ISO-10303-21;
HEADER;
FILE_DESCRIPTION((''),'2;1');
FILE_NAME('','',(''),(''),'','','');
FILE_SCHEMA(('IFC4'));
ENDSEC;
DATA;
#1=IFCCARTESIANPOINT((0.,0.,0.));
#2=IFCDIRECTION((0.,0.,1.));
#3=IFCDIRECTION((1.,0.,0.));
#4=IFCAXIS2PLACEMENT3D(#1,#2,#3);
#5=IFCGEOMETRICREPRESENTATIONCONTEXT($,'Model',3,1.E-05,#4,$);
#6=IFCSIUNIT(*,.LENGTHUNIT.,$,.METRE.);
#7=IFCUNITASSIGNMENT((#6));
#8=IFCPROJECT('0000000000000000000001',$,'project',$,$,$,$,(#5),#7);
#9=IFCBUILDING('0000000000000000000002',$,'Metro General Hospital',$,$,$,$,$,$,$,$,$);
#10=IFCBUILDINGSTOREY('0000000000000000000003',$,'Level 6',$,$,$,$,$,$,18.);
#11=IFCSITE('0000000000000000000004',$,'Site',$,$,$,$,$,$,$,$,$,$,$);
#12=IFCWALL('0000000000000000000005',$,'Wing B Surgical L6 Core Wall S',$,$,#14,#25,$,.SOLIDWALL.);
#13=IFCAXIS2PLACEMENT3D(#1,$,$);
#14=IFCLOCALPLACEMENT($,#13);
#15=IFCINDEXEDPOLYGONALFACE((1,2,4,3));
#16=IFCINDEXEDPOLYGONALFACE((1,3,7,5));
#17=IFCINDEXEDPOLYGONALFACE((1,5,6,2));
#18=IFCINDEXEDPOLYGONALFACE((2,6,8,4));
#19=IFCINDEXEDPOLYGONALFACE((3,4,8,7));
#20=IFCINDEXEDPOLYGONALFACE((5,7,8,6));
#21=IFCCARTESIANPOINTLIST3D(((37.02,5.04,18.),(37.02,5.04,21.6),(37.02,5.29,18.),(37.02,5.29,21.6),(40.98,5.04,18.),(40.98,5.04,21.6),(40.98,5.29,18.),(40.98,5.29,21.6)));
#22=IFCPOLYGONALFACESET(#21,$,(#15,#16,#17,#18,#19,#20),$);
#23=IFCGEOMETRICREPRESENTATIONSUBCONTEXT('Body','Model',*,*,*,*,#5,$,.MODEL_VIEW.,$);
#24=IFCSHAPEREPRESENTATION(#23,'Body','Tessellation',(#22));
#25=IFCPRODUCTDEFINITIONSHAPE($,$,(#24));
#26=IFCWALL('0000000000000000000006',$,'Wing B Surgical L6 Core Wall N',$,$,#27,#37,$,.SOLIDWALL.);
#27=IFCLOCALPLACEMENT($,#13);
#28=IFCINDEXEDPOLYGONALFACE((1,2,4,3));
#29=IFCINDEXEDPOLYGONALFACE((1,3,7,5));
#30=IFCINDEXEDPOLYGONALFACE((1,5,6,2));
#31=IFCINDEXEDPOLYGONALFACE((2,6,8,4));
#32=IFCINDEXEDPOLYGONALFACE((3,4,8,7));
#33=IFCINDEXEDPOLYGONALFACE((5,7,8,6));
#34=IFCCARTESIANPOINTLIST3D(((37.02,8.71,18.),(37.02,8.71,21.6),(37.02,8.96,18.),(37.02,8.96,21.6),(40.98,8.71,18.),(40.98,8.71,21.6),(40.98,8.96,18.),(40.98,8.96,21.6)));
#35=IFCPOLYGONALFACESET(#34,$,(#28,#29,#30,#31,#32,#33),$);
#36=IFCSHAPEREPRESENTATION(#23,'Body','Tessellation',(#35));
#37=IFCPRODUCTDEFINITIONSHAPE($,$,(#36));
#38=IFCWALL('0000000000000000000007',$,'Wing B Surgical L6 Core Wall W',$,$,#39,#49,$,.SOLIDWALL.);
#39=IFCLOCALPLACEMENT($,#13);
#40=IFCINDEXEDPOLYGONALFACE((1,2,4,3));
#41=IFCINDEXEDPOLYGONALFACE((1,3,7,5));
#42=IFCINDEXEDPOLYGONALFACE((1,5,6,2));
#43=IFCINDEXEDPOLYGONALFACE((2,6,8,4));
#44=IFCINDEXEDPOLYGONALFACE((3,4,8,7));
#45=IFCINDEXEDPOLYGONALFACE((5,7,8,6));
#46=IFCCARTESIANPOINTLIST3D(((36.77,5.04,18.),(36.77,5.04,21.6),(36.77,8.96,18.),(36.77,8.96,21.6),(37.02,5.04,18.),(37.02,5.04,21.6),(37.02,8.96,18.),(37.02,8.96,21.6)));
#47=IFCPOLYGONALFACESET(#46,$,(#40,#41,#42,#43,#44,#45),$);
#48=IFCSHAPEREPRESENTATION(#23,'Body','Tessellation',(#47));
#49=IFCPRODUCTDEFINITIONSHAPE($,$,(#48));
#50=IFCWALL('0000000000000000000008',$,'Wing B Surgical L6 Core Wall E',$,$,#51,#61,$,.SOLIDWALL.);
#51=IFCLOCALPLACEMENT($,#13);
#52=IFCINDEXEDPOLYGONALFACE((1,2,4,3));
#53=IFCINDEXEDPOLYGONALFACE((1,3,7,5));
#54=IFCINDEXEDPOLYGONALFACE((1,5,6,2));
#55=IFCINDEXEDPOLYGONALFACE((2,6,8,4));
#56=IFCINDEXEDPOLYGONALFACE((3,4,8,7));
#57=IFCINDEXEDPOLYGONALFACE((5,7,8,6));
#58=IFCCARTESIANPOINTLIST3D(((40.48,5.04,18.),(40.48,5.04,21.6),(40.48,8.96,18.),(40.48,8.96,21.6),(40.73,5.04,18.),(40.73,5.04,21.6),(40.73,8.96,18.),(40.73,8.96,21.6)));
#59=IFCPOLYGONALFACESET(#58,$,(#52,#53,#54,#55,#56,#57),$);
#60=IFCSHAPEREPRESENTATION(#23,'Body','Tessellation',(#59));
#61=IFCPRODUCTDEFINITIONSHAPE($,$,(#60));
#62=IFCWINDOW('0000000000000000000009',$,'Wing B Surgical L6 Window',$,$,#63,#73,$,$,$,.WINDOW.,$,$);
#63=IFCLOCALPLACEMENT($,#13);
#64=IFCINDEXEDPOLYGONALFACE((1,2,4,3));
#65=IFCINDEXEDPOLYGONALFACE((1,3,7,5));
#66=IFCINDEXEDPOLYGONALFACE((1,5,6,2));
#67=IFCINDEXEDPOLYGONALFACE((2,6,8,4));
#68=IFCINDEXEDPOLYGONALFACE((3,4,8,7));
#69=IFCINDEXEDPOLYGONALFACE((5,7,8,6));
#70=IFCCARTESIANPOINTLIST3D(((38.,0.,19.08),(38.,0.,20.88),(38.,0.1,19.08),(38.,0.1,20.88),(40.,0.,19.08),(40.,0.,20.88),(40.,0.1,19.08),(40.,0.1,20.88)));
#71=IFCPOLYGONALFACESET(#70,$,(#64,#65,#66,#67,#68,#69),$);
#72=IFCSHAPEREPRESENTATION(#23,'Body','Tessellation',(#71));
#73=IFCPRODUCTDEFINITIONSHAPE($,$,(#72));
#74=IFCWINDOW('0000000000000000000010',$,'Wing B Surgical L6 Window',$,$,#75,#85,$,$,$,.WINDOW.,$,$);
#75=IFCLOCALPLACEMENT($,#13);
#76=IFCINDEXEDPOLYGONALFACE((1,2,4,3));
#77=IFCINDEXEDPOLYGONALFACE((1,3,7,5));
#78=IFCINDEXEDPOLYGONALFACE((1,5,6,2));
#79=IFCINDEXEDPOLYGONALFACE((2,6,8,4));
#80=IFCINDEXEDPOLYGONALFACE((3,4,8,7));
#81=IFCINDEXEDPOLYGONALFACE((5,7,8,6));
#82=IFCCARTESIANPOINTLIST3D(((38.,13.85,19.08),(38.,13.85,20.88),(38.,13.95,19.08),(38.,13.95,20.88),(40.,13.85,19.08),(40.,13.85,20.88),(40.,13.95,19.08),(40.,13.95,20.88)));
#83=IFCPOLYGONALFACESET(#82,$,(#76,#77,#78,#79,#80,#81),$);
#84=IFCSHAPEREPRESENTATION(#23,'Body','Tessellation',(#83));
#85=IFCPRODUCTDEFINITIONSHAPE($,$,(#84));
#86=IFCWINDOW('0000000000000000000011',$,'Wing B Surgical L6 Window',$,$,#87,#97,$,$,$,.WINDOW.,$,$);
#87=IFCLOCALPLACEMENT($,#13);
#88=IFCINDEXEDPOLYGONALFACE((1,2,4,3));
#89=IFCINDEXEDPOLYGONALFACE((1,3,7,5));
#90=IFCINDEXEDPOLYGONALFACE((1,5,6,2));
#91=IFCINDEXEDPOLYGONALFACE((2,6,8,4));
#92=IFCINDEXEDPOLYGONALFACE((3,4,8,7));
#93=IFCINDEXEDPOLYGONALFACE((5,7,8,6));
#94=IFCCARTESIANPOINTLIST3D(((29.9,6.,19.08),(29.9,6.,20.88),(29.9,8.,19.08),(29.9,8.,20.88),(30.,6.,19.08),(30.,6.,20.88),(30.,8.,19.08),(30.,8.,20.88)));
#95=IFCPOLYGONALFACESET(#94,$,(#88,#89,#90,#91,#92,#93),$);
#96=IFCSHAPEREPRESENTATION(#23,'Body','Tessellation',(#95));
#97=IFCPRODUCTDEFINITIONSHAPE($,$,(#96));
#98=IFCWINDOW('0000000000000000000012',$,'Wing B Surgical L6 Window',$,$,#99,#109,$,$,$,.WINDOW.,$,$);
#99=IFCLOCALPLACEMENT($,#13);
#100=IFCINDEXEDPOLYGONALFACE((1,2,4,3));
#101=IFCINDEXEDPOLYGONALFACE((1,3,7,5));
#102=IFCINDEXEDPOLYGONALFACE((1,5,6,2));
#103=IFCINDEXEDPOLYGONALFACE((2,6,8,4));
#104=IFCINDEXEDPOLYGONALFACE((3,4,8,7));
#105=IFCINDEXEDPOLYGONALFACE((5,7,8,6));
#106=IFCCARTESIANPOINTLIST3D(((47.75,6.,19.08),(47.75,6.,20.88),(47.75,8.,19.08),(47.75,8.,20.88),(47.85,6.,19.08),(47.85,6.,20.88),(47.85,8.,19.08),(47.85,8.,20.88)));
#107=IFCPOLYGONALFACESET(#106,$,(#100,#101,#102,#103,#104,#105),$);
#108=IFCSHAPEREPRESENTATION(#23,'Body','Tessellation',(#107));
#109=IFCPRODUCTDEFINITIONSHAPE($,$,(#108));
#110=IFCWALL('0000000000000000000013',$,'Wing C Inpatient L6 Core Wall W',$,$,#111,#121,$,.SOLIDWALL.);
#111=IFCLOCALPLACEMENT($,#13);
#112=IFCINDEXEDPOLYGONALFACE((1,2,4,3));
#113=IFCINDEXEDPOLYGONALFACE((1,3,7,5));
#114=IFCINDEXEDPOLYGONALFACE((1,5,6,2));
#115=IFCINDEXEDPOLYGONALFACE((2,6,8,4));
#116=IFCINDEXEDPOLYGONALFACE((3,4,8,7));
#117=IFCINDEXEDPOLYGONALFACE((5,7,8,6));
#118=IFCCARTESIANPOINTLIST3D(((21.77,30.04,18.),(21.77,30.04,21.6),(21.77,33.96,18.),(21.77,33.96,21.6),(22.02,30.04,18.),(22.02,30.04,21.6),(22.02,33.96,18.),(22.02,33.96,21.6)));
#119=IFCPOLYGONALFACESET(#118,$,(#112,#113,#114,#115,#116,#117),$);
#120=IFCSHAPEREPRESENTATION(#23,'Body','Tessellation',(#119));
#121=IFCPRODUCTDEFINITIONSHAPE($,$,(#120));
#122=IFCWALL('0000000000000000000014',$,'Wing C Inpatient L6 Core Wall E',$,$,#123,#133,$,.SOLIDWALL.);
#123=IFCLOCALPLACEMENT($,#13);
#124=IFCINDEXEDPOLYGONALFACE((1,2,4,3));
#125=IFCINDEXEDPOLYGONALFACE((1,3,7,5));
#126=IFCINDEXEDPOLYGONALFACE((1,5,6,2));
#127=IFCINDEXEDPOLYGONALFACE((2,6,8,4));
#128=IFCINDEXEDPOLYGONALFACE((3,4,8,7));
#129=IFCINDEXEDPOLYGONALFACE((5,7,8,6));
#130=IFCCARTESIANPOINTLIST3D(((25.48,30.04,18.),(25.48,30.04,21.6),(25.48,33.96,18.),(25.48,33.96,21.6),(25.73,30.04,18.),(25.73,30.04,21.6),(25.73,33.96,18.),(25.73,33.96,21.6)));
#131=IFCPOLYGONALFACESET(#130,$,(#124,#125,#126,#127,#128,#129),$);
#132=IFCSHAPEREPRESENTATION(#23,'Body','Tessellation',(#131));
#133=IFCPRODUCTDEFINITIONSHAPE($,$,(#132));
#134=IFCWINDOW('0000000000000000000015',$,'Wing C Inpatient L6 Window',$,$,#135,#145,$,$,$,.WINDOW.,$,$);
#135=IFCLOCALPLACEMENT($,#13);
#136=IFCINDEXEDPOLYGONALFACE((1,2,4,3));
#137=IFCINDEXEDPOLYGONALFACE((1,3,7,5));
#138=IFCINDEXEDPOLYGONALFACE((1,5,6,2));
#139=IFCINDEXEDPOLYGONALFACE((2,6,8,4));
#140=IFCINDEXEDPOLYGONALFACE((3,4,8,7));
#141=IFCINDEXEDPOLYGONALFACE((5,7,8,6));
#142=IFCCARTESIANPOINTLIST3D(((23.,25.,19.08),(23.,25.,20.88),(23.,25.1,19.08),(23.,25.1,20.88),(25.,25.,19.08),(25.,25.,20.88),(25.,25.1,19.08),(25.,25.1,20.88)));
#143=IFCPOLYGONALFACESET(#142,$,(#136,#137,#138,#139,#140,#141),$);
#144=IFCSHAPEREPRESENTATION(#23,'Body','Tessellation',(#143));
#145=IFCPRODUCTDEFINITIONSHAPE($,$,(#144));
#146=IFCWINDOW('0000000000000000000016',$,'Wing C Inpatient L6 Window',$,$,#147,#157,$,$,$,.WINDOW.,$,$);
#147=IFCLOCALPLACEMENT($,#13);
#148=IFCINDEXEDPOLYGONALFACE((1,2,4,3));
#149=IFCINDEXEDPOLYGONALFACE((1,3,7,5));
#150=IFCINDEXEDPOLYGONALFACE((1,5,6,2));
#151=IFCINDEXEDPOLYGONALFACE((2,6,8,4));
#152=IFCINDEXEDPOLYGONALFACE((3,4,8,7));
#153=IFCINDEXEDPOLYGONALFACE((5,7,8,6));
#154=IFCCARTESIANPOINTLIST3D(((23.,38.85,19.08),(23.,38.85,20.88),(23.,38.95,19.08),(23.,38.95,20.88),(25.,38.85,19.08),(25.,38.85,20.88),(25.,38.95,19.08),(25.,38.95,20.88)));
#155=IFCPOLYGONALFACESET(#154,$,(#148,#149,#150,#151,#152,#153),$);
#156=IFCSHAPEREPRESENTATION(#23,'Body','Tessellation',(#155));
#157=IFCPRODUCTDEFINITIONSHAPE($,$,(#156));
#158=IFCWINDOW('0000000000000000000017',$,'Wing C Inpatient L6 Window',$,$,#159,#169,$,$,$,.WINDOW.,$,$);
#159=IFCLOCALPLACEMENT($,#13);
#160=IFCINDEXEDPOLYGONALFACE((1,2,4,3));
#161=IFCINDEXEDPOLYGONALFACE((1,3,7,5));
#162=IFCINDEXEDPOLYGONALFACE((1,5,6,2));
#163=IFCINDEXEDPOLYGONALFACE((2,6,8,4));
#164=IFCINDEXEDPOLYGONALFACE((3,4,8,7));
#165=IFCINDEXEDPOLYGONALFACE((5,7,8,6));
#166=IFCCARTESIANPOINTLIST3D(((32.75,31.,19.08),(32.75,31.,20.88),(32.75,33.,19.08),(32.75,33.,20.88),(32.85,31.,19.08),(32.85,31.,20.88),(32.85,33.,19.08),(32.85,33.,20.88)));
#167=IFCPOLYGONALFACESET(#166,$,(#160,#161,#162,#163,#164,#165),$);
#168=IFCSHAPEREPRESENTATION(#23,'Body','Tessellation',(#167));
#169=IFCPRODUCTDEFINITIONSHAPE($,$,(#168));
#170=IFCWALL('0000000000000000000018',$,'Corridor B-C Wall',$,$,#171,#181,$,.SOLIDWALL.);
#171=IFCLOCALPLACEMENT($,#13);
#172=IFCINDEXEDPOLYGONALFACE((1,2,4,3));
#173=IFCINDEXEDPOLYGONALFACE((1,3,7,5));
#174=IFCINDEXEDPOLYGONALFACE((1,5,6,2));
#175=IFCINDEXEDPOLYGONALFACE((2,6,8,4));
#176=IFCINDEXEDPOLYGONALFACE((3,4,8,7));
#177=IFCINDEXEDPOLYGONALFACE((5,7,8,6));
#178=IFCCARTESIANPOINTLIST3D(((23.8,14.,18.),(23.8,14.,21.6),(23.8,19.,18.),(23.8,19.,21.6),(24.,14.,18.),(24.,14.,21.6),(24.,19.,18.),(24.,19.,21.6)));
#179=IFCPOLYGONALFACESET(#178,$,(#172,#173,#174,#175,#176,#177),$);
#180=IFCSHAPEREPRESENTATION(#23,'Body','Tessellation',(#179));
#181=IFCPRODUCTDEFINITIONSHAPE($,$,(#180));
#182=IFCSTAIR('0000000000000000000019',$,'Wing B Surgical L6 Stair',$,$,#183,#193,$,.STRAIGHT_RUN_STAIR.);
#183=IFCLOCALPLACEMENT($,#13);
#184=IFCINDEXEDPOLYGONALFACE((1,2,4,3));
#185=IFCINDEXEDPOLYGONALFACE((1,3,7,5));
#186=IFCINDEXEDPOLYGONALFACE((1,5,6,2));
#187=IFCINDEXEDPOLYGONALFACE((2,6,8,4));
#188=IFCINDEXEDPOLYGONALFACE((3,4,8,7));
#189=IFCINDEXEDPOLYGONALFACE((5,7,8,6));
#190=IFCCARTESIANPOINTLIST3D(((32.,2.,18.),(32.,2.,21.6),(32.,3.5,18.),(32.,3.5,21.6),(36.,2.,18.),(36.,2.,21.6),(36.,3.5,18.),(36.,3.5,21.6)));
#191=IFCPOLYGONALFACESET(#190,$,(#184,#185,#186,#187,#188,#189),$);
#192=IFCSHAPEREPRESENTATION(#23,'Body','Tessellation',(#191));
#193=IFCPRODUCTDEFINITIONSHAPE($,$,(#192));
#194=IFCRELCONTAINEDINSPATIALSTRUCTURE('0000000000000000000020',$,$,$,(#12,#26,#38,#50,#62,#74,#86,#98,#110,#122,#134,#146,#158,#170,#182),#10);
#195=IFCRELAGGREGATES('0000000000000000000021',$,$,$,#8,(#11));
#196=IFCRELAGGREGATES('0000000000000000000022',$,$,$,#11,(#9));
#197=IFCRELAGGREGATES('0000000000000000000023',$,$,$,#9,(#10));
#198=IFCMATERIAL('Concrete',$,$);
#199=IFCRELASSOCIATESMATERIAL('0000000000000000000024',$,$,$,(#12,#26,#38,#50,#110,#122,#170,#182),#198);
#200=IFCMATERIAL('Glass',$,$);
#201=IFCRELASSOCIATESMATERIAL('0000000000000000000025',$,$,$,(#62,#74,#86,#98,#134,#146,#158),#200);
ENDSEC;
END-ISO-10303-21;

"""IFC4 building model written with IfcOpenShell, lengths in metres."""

from ifc_helpers import new_model, si_unit, frame, origin_with_axes, place, context, subcontext, project, spatial, line, indexed_curve, outline, extrude, material, element, save


model = new_model("IFC4")

# Units and contexts
model_context = context("Model", 3, precision=1e-05, world=origin_with_axes())
body_context = subcontext(model_context, "Body", "Model", "MODEL_VIEW")
ifc_project = project(units=[si_unit("LENGTHUNIT", "METRE")], contexts=[model_context])

# Site, building, storey
site = spatial("IfcSite", under=ifc_project, Name="Site")
building = spatial("IfcBuilding", under=site, Name="Metro General Hospital")
storey = spatial("IfcBuildingStorey", under=building, Name="Level 6", Elevation=18.0)

# Shared definitions
ifc_material_1 = material(Name="Concrete")

# Walls
for number, where, z_axis, x_axis, name in (
    (1, (37.02, 5.04, 18.0), (0.0, 0.0, 1.0), (1.0, 0.0, 0.0), "Wing B Surgical L6 Core Wall S"),
    (2, (37.02, 8.71, 18.0), (0.0, 0.0, 1.0), (1.0, 0.0, 0.0), "Wing B Surgical L6 Core Wall N"),
):
    element("IfcWall", number, at=place(None, frame(where, z_axis=z_axis, x_axis=x_axis)), inside=storey, material=ifc_material_1, Name=name, PredefinedType="SOLIDWALL", context=body_context, shape_type="SweptSolid", body=[
        extrude(outline(indexed_curve([(0.0, 0.0), (3.96, 0.0), (3.96, 0.25), (0.0, 0.25)], segments=[line(1, 2, 3, 4, 1)])), origin_with_axes(), (0.0, 0.0, 1.0), 3.6),
    ])
for number, where, z_axis, x_axis, name in (
    (3, (37.02, 5.04, 18.0), (0.0, 0.0, 1.0), (0.0, 1.0, 0.0), "Wing B Surgical L6 Core Wall W"),
    (4, (40.73, 5.04, 18.0), (0.0, 0.0, 1.0), (0.0, 1.0, 0.0), "Wing B Surgical L6 Core Wall E"),
):
    element("IfcWall", number, at=place(None, frame(where, z_axis=z_axis, x_axis=x_axis)), inside=storey, material=ifc_material_1, Name=name, PredefinedType="SOLIDWALL", context=body_context, shape_type="SweptSolid", body=[
        extrude(outline(indexed_curve([(0.0, 0.0), (3.92, 0.0), (3.92, 0.25), (0.0, 0.25)], segments=[line(1, 2, 3, 4, 1)])), origin_with_axes(), (0.0, 0.0, 1.0), 3.6),
    ])

# Windows
ifc_material_2 = material(Name="Glass")
for number, where, z_axis, x_axis, name in (
    (5, (38.0, 0.0, 19.08), (0.0, 0.0, 1.0), (1.0, 0.0, 0.0), "Wing B Surgical L6 Window"),
    (6, (38.0, 13.85, 19.08), (0.0, 0.0, 1.0), (1.0, 0.0, 0.0), "Wing B Surgical L6 Window"),
    (7, (30.0, 6.0, 19.08), (0.0, 0.0, 1.0), (0.0, 1.0, 0.0), "Wing B Surgical L6 Window"),
    (8, (47.85, 6.0, 19.08), (0.0, 0.0, 1.0), (0.0, 1.0, 0.0), "Wing B Surgical L6 Window"),
):
    element("IfcWindow", number, at=place(None, frame(where, z_axis=z_axis, x_axis=x_axis)), inside=storey, material=ifc_material_2, Name=name, PredefinedType="WINDOW", context=body_context, shape_type="SweptSolid", body=[
        extrude(outline(indexed_curve([(0.0, 0.0), (2.0, 0.0), (2.0, 0.1), (0.0, 0.1)], segments=[line(1, 2, 3, 4, 1)])), origin_with_axes(), (0.0, 0.0, 1.0), 1.8),
    ])

# Walls
for number, where, z_axis, x_axis, name in (
    (9, (22.02, 30.04, 18.0), (0.0, 0.0, 1.0), (0.0, 1.0, 0.0), "Wing C Inpatient L6 Core Wall W"),
    (10, (25.73, 30.04, 18.0), (0.0, 0.0, 1.0), (0.0, 1.0, 0.0), "Wing C Inpatient L6 Core Wall E"),
):
    element("IfcWall", number, at=place(None, frame(where, z_axis=z_axis, x_axis=x_axis)), inside=storey, material=ifc_material_1, Name=name, PredefinedType="SOLIDWALL", context=body_context, shape_type="SweptSolid", body=[
        extrude(outline(indexed_curve([(0.0, 0.0), (3.92, 0.0), (3.92, 0.25), (0.0, 0.25)], segments=[line(1, 2, 3, 4, 1)])), origin_with_axes(), (0.0, 0.0, 1.0), 3.6),
    ])

# Windows
for number, where, z_axis, x_axis, name in (
    (11, (23.0, 25.0, 19.08), (0.0, 0.0, 1.0), (1.0, 0.0, 0.0), "Wing C Inpatient L6 Window"),
    (12, (23.0, 38.85, 19.08), (0.0, 0.0, 1.0), (1.0, 0.0, 0.0), "Wing C Inpatient L6 Window"),
    (13, (32.85, 31.0, 19.08), (0.0, 0.0, 1.0), (0.0, 1.0, 0.0), "Wing C Inpatient L6 Window"),
):
    element("IfcWindow", number, at=place(None, frame(where, z_axis=z_axis, x_axis=x_axis)), inside=storey, material=ifc_material_2, Name=name, PredefinedType="WINDOW", context=body_context, shape_type="SweptSolid", body=[
        extrude(outline(indexed_curve([(0.0, 0.0), (2.0, 0.0), (2.0, 0.1), (0.0, 0.1)], segments=[line(1, 2, 3, 4, 1)])), origin_with_axes(), (0.0, 0.0, 1.0), 1.8),
    ])

# Wall
wall_placement = place(None, frame((24.0, 14.0, 18.0), z_axis=(0.0, 0.0, 1.0), x_axis=(0.0, 1.0, 0.0)))
element("IfcWall", 14, at=wall_placement, inside=storey, material=ifc_material_1, Name="Corridor B-C Wall", PredefinedType="SOLIDWALL", context=body_context, shape_type="SweptSolid", body=[
    extrude(outline(indexed_curve([(0.0, 0.0), (5.0, 0.0), (5.0, 0.2), (0.0, 0.2)], segments=[line(1, 2, 3, 4, 1)])), origin_with_axes(), (0.0, 0.0, 1.0), 3.6),
])

# Stair
stair_placement = place(None, frame((32.0, 2.0, 18.0), z_axis=(0.0, 0.0, 1.0), x_axis=(1.0, 0.0, 0.0)))
element("IfcStair", 15, at=stair_placement, inside=storey, material=ifc_material_1, Name="Wing B Surgical L6 Stair", PredefinedType="STRAIGHT_RUN_STAIR", context=body_context, shape_type="SweptSolid", body=[
    extrude(outline(indexed_curve([(0.0, 0.0), (4.0, 0.0), (4.0, 1.5), (0.0, 1.5)], segments=[line(1, 2, 3, 4, 1)])), origin_with_axes(), (0.0, 0.0, 1.0), 3.6),
])

save(model, "model.ifc")
